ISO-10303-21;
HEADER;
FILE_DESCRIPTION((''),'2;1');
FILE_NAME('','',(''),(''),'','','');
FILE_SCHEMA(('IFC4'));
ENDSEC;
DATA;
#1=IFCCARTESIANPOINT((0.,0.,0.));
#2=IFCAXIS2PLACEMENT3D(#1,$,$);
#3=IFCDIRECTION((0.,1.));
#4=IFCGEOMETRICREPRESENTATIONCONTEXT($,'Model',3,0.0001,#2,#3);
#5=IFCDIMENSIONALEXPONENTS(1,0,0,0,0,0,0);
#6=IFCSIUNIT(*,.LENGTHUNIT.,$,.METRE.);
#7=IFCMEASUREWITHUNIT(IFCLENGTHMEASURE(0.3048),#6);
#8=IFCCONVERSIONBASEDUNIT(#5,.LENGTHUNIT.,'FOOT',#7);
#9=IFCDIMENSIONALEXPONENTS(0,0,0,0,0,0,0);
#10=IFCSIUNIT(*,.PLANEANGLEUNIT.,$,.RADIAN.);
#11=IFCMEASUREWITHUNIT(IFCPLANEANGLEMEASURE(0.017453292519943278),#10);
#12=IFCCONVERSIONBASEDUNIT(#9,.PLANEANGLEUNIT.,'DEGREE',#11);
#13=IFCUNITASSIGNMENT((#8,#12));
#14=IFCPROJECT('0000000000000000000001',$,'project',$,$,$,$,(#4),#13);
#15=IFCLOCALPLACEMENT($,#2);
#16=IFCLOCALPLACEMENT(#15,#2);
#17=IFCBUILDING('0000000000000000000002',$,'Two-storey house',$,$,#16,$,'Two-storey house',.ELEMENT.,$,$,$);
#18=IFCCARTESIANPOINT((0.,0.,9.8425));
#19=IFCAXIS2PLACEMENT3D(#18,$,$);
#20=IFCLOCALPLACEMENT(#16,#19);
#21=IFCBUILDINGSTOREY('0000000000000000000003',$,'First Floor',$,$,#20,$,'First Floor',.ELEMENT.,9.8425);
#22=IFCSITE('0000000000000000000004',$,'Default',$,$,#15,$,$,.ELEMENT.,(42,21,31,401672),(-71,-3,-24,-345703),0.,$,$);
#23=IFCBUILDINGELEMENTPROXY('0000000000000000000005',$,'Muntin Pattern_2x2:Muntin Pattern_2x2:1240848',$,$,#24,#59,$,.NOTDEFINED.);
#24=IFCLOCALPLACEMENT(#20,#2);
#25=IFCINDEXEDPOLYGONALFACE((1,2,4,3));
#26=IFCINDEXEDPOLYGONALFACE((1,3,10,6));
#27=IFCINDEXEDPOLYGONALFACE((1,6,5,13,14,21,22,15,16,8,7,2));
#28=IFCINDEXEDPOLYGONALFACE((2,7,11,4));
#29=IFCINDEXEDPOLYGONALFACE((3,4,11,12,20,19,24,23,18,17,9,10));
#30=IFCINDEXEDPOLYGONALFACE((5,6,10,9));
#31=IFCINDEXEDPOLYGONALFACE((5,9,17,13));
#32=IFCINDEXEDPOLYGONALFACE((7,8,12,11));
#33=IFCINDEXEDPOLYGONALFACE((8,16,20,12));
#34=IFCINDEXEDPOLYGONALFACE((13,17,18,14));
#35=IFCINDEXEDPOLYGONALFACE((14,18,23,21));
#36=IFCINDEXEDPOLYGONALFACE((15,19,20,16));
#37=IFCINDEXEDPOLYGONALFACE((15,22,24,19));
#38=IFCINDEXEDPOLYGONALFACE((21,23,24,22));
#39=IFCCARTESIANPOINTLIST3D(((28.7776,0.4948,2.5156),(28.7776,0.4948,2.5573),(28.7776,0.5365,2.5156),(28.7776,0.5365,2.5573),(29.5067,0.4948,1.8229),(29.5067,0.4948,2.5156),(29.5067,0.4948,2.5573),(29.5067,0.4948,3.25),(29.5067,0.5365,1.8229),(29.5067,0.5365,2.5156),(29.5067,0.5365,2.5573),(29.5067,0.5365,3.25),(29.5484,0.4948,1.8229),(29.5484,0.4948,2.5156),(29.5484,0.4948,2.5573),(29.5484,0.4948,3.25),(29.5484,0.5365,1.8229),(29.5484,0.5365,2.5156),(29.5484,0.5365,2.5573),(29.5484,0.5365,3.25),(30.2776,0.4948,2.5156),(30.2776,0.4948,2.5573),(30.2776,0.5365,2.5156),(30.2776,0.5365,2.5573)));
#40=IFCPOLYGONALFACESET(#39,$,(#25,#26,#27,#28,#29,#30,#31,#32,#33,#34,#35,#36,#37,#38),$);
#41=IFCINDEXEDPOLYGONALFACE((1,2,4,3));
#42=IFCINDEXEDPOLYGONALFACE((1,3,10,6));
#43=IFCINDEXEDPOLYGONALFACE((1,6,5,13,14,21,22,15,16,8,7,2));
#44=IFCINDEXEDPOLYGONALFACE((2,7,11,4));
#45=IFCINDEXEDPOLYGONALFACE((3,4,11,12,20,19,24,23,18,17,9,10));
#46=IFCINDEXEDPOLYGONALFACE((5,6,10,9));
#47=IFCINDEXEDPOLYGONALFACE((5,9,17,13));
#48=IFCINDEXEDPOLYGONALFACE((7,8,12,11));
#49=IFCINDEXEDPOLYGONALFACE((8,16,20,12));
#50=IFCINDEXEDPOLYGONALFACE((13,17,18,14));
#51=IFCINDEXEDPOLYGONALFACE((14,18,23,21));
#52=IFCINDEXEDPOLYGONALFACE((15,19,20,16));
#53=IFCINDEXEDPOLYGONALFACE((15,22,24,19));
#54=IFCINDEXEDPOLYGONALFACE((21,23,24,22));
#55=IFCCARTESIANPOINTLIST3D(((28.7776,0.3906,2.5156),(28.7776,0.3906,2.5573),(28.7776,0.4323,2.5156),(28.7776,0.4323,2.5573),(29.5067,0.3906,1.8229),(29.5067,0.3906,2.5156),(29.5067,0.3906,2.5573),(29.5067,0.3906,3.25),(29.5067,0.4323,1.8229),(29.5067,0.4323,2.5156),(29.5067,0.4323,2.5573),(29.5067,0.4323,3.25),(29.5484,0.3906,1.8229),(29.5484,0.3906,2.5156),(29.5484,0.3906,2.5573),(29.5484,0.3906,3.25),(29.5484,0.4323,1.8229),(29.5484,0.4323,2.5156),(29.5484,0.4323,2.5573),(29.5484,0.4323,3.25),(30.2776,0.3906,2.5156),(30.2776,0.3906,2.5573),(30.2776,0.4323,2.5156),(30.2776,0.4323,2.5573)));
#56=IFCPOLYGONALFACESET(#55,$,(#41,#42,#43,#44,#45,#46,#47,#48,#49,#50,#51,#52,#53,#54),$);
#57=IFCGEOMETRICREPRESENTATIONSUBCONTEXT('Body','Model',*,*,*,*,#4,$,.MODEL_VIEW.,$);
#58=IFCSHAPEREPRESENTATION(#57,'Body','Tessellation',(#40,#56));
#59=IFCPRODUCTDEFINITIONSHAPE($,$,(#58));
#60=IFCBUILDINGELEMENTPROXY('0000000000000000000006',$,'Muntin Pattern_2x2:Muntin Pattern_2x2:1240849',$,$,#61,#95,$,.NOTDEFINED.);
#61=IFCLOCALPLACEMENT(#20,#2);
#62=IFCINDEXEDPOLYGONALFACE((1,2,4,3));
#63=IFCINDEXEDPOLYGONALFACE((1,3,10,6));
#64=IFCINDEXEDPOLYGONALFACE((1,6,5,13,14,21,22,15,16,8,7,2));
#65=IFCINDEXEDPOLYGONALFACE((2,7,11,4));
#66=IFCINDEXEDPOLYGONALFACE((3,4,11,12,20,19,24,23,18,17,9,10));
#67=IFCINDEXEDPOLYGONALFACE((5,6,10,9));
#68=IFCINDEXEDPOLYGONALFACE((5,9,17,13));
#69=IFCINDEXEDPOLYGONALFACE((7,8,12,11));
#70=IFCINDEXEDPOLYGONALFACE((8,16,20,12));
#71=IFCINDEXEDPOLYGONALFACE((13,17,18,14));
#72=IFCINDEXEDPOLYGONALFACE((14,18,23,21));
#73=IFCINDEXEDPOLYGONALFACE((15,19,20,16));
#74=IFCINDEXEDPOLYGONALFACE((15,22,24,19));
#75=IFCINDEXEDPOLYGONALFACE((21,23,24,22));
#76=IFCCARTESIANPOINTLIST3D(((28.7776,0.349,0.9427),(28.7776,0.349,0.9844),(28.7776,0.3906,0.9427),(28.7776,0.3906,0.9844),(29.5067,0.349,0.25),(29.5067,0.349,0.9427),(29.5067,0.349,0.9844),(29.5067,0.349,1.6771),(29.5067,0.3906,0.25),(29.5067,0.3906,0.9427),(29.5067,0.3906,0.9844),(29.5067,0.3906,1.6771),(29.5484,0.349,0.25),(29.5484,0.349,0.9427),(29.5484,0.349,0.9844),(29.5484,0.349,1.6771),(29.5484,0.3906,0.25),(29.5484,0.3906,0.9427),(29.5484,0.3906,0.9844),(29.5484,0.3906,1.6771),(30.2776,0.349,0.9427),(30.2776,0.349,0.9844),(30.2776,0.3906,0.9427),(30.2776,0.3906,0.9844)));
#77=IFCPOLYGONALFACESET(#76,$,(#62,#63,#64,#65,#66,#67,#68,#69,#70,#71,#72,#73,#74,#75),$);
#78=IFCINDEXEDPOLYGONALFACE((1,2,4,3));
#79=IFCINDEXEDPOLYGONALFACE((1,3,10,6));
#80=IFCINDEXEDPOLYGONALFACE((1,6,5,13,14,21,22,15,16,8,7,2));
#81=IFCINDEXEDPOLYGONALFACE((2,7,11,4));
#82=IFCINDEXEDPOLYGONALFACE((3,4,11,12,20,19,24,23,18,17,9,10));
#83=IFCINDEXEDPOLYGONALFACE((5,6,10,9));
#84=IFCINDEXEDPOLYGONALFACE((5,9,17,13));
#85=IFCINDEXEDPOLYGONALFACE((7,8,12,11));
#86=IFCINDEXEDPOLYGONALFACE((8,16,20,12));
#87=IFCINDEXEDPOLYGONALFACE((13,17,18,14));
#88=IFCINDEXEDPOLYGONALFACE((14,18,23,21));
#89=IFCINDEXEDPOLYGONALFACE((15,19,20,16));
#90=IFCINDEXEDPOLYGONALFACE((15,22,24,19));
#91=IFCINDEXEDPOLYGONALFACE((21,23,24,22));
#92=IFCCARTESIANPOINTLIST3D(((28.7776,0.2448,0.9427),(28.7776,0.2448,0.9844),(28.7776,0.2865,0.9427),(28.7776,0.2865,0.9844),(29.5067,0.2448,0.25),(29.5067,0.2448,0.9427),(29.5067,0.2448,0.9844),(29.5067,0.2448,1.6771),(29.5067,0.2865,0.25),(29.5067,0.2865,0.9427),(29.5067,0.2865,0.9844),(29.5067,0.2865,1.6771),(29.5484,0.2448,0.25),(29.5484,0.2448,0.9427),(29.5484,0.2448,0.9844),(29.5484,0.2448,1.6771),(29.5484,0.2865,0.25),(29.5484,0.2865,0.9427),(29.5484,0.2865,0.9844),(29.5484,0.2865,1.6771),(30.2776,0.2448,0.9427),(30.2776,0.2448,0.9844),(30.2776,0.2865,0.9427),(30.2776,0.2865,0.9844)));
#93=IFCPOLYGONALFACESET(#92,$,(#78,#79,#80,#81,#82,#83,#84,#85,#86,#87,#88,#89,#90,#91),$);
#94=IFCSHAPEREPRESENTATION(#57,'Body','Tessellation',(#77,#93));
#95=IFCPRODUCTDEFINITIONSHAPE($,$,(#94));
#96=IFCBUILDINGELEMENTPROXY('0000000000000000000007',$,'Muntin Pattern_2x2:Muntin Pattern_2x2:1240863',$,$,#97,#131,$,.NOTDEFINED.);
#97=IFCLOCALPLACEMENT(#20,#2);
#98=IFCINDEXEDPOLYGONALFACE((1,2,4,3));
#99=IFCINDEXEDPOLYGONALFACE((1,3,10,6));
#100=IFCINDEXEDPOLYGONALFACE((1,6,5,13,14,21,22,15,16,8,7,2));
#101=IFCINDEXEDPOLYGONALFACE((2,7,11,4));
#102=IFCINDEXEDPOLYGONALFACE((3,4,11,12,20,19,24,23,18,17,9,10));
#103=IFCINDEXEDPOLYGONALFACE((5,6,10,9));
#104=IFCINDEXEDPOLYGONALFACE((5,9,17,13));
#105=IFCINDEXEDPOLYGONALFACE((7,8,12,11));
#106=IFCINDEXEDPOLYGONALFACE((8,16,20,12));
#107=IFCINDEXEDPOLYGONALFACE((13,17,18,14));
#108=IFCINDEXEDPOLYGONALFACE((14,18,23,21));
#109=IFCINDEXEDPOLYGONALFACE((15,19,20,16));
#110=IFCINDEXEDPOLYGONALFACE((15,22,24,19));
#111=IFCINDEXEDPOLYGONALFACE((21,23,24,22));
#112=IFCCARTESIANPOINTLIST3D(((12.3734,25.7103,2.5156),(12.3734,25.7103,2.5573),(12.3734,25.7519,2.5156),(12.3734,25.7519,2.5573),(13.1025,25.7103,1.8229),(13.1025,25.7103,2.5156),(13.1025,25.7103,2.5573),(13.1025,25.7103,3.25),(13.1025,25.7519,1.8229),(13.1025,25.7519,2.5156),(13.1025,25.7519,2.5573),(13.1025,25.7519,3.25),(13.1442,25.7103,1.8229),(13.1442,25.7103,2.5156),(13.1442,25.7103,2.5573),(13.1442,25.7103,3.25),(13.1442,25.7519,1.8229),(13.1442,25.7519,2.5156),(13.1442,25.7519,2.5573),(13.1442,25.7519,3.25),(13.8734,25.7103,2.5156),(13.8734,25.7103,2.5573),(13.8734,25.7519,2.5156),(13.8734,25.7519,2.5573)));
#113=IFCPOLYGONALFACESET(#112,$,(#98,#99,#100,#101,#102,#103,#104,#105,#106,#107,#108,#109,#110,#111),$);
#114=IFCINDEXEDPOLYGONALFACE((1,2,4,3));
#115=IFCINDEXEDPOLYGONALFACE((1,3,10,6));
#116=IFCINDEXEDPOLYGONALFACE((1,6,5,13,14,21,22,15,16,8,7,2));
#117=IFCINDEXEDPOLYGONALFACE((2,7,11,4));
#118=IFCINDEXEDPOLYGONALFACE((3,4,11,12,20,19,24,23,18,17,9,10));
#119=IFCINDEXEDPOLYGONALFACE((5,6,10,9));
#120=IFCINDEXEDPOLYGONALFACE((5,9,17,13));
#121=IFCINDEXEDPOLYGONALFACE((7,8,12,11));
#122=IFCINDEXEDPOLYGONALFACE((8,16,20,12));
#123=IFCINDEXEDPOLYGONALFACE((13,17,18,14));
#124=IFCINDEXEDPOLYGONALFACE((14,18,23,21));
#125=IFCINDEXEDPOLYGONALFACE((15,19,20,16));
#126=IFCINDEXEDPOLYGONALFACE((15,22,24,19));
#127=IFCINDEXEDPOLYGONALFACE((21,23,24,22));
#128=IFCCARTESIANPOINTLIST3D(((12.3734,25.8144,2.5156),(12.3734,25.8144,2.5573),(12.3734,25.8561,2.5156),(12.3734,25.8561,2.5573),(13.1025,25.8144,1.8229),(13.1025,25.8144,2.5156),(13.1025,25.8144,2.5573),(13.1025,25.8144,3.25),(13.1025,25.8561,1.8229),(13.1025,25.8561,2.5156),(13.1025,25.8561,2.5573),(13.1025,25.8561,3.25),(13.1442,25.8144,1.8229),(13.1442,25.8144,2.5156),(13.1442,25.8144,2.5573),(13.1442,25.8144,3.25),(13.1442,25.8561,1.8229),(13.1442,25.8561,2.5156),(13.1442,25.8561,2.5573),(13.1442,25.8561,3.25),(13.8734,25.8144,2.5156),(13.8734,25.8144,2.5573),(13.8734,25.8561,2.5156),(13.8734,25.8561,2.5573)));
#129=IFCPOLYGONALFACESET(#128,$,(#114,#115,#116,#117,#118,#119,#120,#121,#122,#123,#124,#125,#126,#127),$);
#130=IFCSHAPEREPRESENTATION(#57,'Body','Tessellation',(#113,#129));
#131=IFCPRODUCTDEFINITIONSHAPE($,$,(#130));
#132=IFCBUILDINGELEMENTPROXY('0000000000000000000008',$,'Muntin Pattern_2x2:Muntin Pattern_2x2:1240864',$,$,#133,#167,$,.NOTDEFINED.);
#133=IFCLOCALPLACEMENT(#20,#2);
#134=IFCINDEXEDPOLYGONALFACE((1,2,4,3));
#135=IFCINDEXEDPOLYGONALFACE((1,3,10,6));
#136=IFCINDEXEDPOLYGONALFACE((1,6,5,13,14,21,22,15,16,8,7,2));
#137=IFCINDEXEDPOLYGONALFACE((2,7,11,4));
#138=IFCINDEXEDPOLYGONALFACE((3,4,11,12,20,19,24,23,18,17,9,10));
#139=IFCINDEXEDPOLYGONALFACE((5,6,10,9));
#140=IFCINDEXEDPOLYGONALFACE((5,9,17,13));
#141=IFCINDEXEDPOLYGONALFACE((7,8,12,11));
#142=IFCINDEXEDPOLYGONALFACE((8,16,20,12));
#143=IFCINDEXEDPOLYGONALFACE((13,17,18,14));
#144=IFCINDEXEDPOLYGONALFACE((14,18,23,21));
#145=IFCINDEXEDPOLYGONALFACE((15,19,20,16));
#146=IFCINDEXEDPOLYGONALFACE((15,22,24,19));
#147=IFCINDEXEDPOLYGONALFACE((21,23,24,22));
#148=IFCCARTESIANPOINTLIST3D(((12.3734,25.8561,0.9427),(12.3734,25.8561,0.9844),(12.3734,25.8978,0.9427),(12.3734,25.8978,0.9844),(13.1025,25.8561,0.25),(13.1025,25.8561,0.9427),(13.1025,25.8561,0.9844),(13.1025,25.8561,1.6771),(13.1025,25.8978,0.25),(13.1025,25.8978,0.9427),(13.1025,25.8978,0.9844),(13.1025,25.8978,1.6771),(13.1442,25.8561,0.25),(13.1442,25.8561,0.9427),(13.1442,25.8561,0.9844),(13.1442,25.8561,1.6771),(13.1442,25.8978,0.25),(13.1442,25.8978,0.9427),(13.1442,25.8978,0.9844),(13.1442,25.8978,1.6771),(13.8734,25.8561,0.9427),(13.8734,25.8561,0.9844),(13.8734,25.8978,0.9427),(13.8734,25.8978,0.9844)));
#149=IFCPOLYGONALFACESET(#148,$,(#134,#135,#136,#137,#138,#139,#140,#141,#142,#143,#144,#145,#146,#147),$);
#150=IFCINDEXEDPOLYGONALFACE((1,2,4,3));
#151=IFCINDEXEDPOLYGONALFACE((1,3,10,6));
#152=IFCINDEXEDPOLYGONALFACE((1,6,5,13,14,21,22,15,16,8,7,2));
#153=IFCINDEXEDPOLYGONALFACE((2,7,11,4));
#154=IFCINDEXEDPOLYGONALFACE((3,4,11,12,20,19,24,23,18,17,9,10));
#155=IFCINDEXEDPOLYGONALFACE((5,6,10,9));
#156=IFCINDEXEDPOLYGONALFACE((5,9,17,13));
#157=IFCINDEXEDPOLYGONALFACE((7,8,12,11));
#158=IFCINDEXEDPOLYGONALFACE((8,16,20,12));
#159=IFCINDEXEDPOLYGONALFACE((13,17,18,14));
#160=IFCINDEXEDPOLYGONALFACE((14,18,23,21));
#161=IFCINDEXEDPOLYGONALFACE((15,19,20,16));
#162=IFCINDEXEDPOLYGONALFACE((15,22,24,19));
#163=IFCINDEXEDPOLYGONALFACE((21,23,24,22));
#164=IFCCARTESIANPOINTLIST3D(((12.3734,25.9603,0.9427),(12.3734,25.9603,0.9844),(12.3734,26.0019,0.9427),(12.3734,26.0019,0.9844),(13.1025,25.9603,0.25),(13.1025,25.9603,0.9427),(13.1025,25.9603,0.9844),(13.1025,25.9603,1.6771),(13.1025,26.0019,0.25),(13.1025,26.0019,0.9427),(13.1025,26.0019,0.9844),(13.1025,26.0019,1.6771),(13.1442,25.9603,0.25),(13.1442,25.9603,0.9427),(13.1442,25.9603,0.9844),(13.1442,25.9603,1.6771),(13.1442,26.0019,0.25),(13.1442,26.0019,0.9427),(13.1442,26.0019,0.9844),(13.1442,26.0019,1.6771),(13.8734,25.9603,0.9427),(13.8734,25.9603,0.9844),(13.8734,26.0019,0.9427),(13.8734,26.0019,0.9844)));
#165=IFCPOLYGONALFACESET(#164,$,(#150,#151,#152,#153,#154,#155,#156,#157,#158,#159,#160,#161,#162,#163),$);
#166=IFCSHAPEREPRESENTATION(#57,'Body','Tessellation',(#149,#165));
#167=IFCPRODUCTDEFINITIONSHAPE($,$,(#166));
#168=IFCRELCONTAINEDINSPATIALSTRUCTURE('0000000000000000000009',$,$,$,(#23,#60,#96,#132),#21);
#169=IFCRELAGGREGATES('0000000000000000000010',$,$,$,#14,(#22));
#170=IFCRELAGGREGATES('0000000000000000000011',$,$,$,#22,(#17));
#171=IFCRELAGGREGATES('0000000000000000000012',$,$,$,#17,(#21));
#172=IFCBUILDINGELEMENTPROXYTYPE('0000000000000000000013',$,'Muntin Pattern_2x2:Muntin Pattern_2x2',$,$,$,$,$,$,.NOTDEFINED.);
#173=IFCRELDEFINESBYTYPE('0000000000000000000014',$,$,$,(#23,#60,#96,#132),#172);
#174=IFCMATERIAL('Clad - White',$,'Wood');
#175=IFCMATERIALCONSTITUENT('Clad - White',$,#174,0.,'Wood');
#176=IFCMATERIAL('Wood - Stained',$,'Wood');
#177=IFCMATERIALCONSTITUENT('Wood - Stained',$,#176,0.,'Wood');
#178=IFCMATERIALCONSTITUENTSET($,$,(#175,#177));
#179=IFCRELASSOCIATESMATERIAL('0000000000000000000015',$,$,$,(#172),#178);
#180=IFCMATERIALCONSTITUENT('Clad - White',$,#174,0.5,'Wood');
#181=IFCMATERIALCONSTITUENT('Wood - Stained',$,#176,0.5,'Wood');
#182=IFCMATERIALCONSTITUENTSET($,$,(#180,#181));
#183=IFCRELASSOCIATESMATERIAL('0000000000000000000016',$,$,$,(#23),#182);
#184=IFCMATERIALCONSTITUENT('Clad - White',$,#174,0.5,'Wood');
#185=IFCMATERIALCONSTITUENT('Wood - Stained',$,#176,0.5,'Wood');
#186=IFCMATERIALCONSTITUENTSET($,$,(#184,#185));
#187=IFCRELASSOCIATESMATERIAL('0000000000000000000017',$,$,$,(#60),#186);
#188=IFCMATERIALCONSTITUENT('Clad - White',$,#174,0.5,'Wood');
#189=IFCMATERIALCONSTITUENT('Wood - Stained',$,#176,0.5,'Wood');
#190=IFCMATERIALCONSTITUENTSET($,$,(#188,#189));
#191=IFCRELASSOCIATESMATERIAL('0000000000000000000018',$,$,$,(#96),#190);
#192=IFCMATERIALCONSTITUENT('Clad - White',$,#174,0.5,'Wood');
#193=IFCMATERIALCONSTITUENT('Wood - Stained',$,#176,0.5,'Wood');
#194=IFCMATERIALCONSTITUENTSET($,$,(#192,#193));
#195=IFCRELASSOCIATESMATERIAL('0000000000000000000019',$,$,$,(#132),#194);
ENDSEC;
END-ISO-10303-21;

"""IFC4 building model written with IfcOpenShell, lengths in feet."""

from ifc_helpers import new_model, entity, si_unit, converted_unit, direction, frame, origin, place, context, subcontext, project, spatial, indexed_curve, outline, extrude, source, transform, mapped, material, constituent, constituent_set, type_object, type_shapes, element, save


model = new_model("IFC4")

# Units and contexts
model_context = context("Model", 3, precision=0.0001, world=origin(), true_north=direction((0.0, 1.0)))
body_context = subcontext(model_context, "Body", "Model", "MODEL_VIEW")
ifc_project = project(units=[converted_unit("LENGTHUNIT", "FOOT", entity("IfcLengthMeasure", 0.3048), si_unit("LENGTHUNIT", "METRE"), dimensions=[1, 0, 0, 0, 0, 0, 0]), converted_unit("PLANEANGLEUNIT", "DEGREE", entity("IfcPlaneAngleMeasure", 0.017453292519943278), si_unit("PLANEANGLEUNIT", "RADIAN"), dimensions=[0, 0, 0, 0, 0, 0, 0])], contexts=[model_context])

# Site, building, storey
site_placement = place(None, origin())
site = spatial("IfcSite", under=ifc_project, at=site_placement, Name="Default", CompositionType="ELEMENT", RefLatitude=(42, 21, 31, 401672), RefLongitude=(-71, -3, -24, -345703), RefElevation=0.0)
building_placement = place(site_placement, origin())
building = spatial("IfcBuilding", under=site, at=building_placement, Name="Two-storey house", LongName="Two-storey house", CompositionType="ELEMENT")
storey_placement = place(building_placement, frame((0.0, 0.0, 9.8425)))
storey = spatial("IfcBuildingStorey", under=building, at=storey_placement, Name="First Floor", LongName="First Floor", CompositionType="ELEMENT", Elevation=9.8425)

# Shared definitions
ifc_material_1 = material(Name="Wood - Stained", Category="Wood")

# Building element proxies
ifc_material_2 = material(Name="Clad - White", Category="Wood")
ifc_constituent_1 = constituent(ifc_material_2, Name="Clad - White", Category="Wood", fraction=0.5)
ifc_constituent_2 = constituent(ifc_material_1, Name="Wood - Stained", Category="Wood", fraction=0.5)
ifc_constituent_set_1 = constituent_set(constituents=[ifc_constituent_1, ifc_constituent_2])
ifc_constituent_3 = constituent(ifc_material_2, Name="Clad - White", Category="Wood", fraction=0.0)
ifc_constituent_4 = constituent(ifc_material_1, Name="Wood - Stained", Category="Wood", fraction=0.0)
ifc_constituent_set_2 = constituent_set(constituents=[ifc_constituent_3, ifc_constituent_4])
building_element_proxy_type_1 = type_object("IfcBuildingElementProxyType", Name="Muntin Pattern_2x2:Muntin Pattern_2x2", PredefinedType="NOTDEFINED", material=ifc_constituent_set_2)
shared_shape_1 = source(origin(), body_context, "Body", "SweptSolid", [
    extrude(outline(indexed_curve([(0.0208, -0.0208), (0.7135, -0.0208), (0.7135, 0.0208), (0.0208, 0.0208), (0.0208, 0.75), (-0.0208, 0.75), (-0.0208, 0.0208), (-0.7135, 0.0208), (-0.7135, -0.0208), (-0.0208, -0.0208), (-0.0208, -0.75), (0.0208, -0.75), (0.0208, -0.0208)], self_intersect=False)), frame((0.0, 0.0312, 0.7135), z_axis=(0.0, 1.0, 0.0), x_axis=(0.0, 0.0, 1.0)), (0.0, 0.0, 1.0), 0.0417),
    extrude(outline(indexed_curve([(0.0208, -0.0208), (0.7135, -0.0208), (0.7135, 0.0208), (0.0208, 0.0208), (0.0208, 0.75), (-0.0208, 0.75), (-0.0208, 0.0208), (-0.7135, 0.0208), (-0.7135, -0.0208), (-0.0208, -0.0208), (-0.0208, -0.75), (0.0208, -0.75), (0.0208, -0.0208)], self_intersect=False)), frame((0.0, -0.0729, 0.7135), z_axis=(0.0, 1.0, 0.0), x_axis=(0.0, 0.0, 1.0)), (0.0, 0.0, 1.0), 0.0417),
])
type_shapes(building_element_proxy_type_1, [shared_shape_1])
proxy_1_placement = place(storey_placement, frame((29.5276, 0.4635, 1.8229)))
element("IfcBuildingElementProxy", 1, at=proxy_1_placement, inside=storey, type_object=building_element_proxy_type_1, material=ifc_constituent_set_1, Name="Muntin Pattern_2x2:Muntin Pattern_2x2:1240848", PredefinedType="NOTDEFINED", context=body_context, shape_type="MappedRepresentation", body=[
    mapped(shared_shape_1, transform((0.0, 0.0, 0.0), scale=1.0)),
])
ifc_constituent_5 = constituent(ifc_material_2, Name="Clad - White", Category="Wood", fraction=0.5)
ifc_constituent_6 = constituent(ifc_material_1, Name="Wood - Stained", Category="Wood", fraction=0.5)
ifc_constituent_set_3 = constituent_set(constituents=[ifc_constituent_5, ifc_constituent_6])
proxy_2_placement = place(storey_placement, frame((29.5276, 0.3177, 0.25)))
element("IfcBuildingElementProxy", 2, at=proxy_2_placement, inside=storey, type_object=building_element_proxy_type_1, material=ifc_constituent_set_3, Name="Muntin Pattern_2x2:Muntin Pattern_2x2:1240849", PredefinedType="NOTDEFINED", context=body_context, shape_type="MappedRepresentation", body=[
    mapped(shared_shape_1, transform((0.0, 0.0, 0.0), scale=1.0)),
])
ifc_constituent_7 = constituent(ifc_material_2, Name="Clad - White", Category="Wood", fraction=0.5)
ifc_constituent_8 = constituent(ifc_material_1, Name="Wood - Stained", Category="Wood", fraction=0.5)
ifc_constituent_set_4 = constituent_set(constituents=[ifc_constituent_7, ifc_constituent_8])
proxy_3_placement = place(storey_placement, frame((13.1234, 25.7832, 1.8229), z_axis=(0.0, 0.0, 1.0), x_axis=(-1.0, 0.0, 0.0)))
element("IfcBuildingElementProxy", 3, at=proxy_3_placement, inside=storey, type_object=building_element_proxy_type_1, material=ifc_constituent_set_4, Name="Muntin Pattern_2x2:Muntin Pattern_2x2:1240863", PredefinedType="NOTDEFINED", context=body_context, shape_type="MappedRepresentation", body=[
    mapped(shared_shape_1, transform((0.0, 0.0, 0.0), scale=1.0)),
])
ifc_constituent_9 = constituent(ifc_material_2, Name="Clad - White", Category="Wood", fraction=0.5)
ifc_constituent_10 = constituent(ifc_material_1, Name="Wood - Stained", Category="Wood", fraction=0.5)
ifc_constituent_set_5 = constituent_set(constituents=[ifc_constituent_9, ifc_constituent_10])
proxy_4_placement = place(storey_placement, frame((13.1234, 25.929, 0.25), z_axis=(0.0, 0.0, 1.0), x_axis=(-1.0, 0.0, 0.0)))
element("IfcBuildingElementProxy", 4, at=proxy_4_placement, inside=storey, type_object=building_element_proxy_type_1, material=ifc_constituent_set_5, Name="Muntin Pattern_2x2:Muntin Pattern_2x2:1240864", PredefinedType="NOTDEFINED", context=body_context, shape_type="MappedRepresentation", body=[
    mapped(shared_shape_1, transform((0.0, 0.0, 0.0), scale=1.0)),
])

save(model, "model.ifc")
